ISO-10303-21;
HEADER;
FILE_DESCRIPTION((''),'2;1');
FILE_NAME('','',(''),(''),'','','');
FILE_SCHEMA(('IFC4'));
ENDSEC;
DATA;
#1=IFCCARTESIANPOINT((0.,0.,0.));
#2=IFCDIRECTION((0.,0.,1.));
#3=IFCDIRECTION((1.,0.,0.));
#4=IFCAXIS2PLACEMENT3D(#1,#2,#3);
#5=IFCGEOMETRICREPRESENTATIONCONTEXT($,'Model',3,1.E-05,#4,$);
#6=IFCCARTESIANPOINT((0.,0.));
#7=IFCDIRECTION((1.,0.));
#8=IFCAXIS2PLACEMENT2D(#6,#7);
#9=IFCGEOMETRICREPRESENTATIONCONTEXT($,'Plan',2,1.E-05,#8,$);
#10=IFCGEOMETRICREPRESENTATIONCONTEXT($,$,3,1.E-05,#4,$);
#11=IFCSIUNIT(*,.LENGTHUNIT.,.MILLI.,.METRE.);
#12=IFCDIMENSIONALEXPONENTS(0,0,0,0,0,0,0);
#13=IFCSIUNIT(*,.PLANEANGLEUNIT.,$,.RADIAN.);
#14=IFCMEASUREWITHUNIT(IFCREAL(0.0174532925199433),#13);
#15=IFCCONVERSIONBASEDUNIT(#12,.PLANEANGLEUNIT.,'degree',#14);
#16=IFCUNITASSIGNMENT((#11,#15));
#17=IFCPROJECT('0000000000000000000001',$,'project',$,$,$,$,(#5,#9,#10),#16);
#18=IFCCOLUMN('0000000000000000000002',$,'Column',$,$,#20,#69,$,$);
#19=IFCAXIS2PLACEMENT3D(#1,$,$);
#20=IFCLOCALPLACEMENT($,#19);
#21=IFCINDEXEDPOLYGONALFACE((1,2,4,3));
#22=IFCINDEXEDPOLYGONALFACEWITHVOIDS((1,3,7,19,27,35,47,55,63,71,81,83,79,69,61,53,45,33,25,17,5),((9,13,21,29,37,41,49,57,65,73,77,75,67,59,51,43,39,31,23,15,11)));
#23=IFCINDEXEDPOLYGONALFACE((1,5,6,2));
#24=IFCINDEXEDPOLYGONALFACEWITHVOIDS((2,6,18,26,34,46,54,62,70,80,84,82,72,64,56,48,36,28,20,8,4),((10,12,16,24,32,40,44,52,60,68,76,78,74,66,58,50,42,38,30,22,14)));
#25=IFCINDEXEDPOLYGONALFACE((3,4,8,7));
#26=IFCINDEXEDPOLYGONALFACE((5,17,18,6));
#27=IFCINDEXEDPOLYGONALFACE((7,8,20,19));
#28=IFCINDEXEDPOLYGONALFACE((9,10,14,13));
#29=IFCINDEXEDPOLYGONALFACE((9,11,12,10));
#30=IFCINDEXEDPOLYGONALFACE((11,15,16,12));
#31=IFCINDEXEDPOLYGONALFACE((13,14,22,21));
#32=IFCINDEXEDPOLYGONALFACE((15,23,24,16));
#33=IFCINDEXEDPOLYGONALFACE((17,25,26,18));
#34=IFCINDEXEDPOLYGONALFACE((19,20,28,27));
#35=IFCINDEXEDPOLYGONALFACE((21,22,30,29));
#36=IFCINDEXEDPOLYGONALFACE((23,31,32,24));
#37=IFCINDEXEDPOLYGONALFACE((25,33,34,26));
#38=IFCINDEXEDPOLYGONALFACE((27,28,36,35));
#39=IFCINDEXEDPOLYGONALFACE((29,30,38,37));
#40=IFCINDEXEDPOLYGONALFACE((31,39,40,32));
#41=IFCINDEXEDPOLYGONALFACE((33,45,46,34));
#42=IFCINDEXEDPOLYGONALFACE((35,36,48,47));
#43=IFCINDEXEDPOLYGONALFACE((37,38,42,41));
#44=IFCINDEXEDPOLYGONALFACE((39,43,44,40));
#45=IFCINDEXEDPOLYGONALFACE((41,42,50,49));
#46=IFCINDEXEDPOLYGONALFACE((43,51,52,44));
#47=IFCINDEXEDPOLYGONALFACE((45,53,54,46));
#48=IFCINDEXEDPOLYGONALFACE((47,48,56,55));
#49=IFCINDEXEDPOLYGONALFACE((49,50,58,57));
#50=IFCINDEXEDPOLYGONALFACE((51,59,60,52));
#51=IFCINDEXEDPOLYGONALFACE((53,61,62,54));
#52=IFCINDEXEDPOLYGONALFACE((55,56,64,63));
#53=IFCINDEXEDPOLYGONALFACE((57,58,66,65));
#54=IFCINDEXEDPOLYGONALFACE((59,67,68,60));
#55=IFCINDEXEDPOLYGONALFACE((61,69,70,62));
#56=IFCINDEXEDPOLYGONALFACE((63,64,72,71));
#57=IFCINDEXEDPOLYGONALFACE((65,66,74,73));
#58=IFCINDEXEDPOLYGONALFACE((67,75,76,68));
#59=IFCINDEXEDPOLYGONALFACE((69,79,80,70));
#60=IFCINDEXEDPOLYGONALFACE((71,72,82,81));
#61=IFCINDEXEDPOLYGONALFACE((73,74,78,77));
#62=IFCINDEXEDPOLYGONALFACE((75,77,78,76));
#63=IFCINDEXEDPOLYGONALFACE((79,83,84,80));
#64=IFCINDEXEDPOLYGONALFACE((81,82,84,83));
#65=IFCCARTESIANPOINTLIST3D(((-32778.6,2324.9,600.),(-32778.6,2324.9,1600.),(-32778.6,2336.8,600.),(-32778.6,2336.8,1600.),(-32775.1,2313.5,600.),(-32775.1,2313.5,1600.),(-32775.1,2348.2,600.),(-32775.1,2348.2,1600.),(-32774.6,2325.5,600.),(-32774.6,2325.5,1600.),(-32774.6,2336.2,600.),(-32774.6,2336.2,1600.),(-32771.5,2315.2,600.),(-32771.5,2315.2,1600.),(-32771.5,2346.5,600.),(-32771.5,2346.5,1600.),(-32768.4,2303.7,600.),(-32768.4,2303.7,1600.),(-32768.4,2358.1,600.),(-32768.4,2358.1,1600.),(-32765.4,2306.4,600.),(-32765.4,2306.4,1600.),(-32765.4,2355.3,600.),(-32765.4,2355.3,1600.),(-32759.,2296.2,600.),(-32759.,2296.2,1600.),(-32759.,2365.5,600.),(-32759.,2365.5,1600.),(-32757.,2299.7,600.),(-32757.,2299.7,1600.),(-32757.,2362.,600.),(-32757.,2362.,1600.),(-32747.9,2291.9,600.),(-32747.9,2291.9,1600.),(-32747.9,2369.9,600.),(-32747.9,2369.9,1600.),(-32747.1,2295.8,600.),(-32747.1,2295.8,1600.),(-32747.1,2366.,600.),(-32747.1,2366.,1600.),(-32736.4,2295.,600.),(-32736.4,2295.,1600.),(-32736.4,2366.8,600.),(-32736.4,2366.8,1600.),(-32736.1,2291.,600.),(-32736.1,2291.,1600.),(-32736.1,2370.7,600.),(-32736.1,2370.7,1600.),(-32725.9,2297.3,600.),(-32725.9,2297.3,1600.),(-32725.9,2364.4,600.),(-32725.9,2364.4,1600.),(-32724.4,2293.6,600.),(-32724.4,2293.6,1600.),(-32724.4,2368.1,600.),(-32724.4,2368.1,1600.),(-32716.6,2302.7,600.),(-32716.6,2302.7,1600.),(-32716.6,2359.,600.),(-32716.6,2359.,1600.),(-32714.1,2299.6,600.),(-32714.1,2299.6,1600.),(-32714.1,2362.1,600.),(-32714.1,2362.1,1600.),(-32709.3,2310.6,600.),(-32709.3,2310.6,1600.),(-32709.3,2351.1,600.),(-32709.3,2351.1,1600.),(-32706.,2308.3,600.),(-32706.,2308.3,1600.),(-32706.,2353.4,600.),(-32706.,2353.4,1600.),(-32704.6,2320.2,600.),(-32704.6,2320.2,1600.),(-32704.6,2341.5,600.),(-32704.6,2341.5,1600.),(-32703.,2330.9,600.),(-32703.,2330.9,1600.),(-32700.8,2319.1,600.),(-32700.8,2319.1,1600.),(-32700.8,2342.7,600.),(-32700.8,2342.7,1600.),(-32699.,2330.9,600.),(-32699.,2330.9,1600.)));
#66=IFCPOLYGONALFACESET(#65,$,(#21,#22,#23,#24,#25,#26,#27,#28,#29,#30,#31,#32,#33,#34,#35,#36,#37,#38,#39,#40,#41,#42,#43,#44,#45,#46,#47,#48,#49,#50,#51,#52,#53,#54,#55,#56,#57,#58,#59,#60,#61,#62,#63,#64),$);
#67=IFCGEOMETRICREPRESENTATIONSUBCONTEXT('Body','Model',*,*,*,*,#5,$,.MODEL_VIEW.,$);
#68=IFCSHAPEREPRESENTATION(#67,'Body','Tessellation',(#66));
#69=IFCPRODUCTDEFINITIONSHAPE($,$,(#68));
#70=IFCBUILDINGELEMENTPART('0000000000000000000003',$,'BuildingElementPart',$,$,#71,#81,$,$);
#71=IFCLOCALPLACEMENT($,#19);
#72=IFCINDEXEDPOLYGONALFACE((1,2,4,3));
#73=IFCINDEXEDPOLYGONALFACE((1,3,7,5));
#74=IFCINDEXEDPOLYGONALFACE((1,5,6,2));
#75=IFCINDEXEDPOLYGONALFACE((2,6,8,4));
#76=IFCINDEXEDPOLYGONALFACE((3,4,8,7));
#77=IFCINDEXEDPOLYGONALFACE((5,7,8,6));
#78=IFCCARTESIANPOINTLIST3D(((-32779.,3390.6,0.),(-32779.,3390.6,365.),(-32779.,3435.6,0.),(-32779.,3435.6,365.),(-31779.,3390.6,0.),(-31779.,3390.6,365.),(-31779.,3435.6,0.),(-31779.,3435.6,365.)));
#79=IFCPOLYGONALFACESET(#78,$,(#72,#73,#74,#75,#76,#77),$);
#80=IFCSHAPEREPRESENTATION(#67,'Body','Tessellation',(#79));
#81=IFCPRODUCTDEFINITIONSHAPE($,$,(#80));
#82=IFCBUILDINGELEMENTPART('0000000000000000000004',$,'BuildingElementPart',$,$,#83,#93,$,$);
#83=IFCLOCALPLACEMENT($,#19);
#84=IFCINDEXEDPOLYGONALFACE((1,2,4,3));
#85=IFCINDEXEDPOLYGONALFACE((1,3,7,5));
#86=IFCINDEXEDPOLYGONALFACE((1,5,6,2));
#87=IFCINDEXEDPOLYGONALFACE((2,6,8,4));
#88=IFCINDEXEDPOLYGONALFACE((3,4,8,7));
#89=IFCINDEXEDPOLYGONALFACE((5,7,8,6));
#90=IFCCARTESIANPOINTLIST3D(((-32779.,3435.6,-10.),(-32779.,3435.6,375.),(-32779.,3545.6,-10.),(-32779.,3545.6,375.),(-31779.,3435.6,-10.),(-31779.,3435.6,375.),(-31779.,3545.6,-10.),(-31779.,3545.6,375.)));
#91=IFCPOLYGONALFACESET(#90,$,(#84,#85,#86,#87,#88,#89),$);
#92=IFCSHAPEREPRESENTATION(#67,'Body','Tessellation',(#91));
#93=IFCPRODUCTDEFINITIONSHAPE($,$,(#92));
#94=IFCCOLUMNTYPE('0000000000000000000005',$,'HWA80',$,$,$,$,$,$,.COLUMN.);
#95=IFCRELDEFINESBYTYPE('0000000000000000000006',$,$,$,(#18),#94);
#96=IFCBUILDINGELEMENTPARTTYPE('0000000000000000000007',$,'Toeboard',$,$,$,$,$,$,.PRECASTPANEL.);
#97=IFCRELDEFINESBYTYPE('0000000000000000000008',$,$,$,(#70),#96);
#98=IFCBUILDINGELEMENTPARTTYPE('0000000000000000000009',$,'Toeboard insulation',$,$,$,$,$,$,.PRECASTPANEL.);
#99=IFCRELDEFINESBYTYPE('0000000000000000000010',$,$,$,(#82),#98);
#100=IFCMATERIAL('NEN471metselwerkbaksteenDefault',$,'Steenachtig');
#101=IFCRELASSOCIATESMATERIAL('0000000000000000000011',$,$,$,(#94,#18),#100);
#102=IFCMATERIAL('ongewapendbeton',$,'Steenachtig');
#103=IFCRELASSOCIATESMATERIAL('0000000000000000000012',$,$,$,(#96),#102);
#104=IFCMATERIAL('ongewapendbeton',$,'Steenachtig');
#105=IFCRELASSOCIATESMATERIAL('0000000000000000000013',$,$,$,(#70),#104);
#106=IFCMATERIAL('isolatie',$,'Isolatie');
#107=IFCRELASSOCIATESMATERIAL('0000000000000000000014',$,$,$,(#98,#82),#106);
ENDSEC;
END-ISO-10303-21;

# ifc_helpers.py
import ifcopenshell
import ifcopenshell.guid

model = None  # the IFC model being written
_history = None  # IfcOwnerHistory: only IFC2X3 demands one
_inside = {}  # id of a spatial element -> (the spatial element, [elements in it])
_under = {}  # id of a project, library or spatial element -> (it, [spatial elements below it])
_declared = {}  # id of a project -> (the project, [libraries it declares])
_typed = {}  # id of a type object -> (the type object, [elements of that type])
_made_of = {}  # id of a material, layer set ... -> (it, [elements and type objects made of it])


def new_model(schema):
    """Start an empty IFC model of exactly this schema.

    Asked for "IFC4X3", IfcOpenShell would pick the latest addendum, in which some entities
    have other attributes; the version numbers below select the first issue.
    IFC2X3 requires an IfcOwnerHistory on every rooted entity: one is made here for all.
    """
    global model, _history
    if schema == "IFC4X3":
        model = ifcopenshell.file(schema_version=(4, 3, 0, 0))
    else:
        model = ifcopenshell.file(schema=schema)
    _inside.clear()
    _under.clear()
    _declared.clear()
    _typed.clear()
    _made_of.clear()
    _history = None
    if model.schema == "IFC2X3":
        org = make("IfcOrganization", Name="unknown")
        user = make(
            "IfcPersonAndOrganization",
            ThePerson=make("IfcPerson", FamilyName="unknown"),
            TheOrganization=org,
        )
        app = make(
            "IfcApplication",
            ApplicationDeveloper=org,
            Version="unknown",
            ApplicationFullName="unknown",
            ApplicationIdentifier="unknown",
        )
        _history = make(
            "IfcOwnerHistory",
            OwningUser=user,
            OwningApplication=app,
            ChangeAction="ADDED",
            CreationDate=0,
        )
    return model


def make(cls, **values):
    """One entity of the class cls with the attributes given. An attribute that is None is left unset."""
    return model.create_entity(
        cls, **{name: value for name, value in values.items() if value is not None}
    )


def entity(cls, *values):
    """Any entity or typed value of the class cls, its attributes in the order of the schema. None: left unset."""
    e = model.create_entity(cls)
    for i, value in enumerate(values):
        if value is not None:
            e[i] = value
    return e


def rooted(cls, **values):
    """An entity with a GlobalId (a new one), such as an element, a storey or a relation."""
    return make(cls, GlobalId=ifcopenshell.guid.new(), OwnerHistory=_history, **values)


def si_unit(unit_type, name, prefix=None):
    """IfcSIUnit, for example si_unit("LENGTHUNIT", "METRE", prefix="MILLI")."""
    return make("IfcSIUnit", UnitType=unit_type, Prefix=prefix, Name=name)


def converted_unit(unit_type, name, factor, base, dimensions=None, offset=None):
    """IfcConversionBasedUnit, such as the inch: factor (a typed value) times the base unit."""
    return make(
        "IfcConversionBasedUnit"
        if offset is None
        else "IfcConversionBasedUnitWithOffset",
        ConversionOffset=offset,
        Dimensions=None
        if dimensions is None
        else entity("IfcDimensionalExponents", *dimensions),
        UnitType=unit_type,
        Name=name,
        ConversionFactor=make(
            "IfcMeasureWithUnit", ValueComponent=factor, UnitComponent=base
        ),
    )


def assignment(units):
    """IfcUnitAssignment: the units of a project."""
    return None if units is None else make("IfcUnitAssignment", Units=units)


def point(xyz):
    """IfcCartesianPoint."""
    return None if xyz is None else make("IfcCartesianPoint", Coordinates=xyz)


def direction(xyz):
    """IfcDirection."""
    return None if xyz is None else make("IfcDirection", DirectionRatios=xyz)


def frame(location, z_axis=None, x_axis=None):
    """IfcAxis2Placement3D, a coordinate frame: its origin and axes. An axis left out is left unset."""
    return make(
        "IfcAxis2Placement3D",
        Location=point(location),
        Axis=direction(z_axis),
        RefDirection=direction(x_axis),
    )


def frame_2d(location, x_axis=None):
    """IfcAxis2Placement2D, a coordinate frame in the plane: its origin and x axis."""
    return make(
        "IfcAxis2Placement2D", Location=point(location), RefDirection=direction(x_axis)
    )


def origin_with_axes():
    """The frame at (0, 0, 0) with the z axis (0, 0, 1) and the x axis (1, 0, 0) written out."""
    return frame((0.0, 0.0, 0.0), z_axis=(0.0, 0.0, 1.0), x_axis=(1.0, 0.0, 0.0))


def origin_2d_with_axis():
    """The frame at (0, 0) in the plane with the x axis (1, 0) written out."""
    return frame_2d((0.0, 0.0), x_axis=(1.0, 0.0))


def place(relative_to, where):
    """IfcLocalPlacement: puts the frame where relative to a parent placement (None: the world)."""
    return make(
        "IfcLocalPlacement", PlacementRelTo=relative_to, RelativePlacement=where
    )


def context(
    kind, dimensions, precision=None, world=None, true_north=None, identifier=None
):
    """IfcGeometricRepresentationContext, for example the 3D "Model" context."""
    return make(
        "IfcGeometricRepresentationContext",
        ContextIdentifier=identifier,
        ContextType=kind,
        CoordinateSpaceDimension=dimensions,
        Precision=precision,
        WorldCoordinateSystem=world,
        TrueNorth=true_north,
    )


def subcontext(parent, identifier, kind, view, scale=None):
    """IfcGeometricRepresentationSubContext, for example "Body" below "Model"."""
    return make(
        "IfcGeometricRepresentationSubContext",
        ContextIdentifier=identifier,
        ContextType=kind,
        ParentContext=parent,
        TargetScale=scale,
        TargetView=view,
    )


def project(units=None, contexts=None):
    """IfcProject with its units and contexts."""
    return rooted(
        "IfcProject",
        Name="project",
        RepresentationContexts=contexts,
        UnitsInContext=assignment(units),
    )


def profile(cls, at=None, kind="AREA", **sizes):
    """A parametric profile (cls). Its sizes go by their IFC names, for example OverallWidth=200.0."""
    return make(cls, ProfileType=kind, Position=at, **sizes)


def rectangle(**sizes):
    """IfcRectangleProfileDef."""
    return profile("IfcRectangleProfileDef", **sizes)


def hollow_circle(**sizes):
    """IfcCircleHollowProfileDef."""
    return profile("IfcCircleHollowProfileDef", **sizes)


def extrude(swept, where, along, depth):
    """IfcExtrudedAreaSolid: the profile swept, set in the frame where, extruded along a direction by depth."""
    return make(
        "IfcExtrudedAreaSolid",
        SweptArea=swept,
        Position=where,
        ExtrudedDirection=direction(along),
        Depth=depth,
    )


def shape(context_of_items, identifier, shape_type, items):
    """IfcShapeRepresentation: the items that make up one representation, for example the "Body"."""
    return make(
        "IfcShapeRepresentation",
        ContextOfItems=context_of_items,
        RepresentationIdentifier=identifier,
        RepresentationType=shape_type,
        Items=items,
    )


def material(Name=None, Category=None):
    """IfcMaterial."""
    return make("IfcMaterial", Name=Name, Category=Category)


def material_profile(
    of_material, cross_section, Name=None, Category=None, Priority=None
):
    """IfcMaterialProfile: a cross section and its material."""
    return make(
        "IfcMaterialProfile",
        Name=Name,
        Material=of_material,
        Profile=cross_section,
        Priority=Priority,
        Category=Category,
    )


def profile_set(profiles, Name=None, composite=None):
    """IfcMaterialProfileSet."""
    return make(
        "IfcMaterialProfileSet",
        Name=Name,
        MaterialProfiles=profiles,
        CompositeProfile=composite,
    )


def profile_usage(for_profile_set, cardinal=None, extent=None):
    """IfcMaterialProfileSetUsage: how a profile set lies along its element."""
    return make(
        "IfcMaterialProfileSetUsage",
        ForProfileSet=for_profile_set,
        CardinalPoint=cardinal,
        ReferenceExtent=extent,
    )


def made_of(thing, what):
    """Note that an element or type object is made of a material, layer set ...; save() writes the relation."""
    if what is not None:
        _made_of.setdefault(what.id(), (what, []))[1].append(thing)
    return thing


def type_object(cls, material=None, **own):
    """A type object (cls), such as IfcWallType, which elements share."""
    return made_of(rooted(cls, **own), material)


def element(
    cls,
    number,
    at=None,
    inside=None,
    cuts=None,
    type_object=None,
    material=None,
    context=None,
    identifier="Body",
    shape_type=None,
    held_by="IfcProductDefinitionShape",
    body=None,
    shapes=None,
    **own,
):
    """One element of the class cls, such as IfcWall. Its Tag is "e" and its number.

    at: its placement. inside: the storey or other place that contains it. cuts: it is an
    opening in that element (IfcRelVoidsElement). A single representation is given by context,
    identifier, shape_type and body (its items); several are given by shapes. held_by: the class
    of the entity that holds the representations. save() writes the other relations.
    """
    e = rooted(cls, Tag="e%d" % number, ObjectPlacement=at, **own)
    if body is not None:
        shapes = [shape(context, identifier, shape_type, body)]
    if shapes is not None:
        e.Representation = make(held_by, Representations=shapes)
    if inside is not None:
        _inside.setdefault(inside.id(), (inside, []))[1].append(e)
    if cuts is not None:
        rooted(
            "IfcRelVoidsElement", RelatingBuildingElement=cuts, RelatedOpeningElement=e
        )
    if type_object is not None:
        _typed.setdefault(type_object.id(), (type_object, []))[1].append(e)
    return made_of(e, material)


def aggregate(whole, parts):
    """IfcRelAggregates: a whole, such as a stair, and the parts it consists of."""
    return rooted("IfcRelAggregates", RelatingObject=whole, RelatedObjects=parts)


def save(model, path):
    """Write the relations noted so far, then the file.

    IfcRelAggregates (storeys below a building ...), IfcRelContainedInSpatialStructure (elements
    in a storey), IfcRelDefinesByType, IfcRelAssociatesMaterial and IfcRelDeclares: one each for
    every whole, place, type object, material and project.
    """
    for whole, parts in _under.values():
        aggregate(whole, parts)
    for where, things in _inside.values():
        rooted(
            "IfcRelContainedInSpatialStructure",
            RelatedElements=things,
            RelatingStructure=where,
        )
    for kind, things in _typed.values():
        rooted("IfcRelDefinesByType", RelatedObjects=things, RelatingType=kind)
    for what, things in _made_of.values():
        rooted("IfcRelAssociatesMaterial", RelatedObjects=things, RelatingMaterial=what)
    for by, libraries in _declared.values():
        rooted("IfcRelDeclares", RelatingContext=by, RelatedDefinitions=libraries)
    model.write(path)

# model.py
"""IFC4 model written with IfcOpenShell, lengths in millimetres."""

from ifc_helpers import new_model, entity, si_unit, converted_unit, frame, origin_with_axes, origin_2d_with_axis, place, context, subcontext, project, rectangle, hollow_circle, extrude, material, material_profile, profile_set, profile_usage, type_object, element, save


model = new_model("IFC4")

# Units and contexts
model_context = context("Model", 3, precision=1e-05, world=origin_with_axes())
plan_context = context("Plan", 2, precision=1e-05, world=origin_2d_with_axis())
context_of_model = context(None, 3, precision=1e-05, world=origin_with_axes())
body_context = subcontext(model_context, "Body", "Model", "MODEL_VIEW")
ifc_project = project(units=[si_unit("LENGTHUNIT", "METRE", prefix="MILLI"), converted_unit("PLANEANGLEUNIT", "degree", entity("IfcReal", 0.0174532925199433), si_unit("PLANEANGLEUNIT", "RADIAN"), dimensions=[0, 0, 0, 0, 0, 0, 0])], contexts=[model_context, plan_context, context_of_model])

# Column
ifc_material_1 = material(Name="NEN471metselwerkbaksteenDefault", Category="Steenachtig")
ifc_material_profile_1 = material_profile(ifc_material_1, hollow_circle(Radius=40.0, WallThickness=4.0))
ifc_profile_set_1 = profile_set([ifc_material_profile_1])
ifc_profile_usage_1 = profile_usage(ifc_profile_set_1, cardinal=5)
column_type = type_object("IfcColumnType", Name="HWA80", PredefinedType="COLUMN", material=ifc_profile_set_1)
column_placement = place(None, frame((-32739.0, 2330.9, 600.0), z_axis=(0.0, 0.0, 1.0), x_axis=(1.0, 0.0, 0.0)))
element("IfcColumn", 1, at=column_placement, type_object=column_type, material=ifc_profile_usage_1, Name="Column", context=body_context, shape_type="SweptSolid", body=[
    extrude(hollow_circle(Radius=40.0, WallThickness=4.0), origin_with_axes(), (0.0, 0.0, 1.0), 1000.0),
])

# Building element parts
ifc_material_2 = material(Name="ongewapendbeton", Category="Steenachtig")
ifc_material_3 = material(Name="ongewapendbeton", Category="Steenachtig")
ifc_material_profile_2 = material_profile(ifc_material_3, rectangle(XDim=45.0, YDim=365.0))
ifc_profile_set_2 = profile_set([ifc_material_profile_2], Name="ongewapendbeton")
building_element_part_type_1 = type_object("IfcBuildingElementPartType", Name="Toeboard", PredefinedType="PRECASTPANEL", material=ifc_profile_set_2)
building_element_part_1_placement = place(None, frame((-32779.0, 3413.1, 182.5), z_axis=(1.0, 0.0, 0.0), x_axis=(0.0, 1.0, 0.0)))
element("IfcBuildingElementPart", 2, at=building_element_part_1_placement, type_object=building_element_part_type_1, material=ifc_material_2, Name="BuildingElementPart", context=body_context, shape_type="SweptSolid", body=[
    extrude(rectangle(XDim=45.0, YDim=365.0), origin_with_axes(), (0.0, 0.0, 1.0), 1000.0),
])
ifc_material_4 = material(Name="isolatie", Category="Isolatie")
ifc_material_profile_3 = material_profile(ifc_material_4, rectangle(XDim=110.0, YDim=385.0))
ifc_profile_set_3 = profile_set([ifc_material_profile_3], Name="isolatieEPS")
ifc_profile_usage_2 = profile_usage(ifc_profile_set_3, cardinal=5)
building_element_part_type_2 = type_object("IfcBuildingElementPartType", Name="Toeboard insulation", PredefinedType="PRECASTPANEL", material=ifc_profile_set_3)
building_element_part_2_placement = place(None, frame((-32779.0, 3490.6, 182.5), z_axis=(1.0, 0.0, 0.0), x_axis=(0.0, 1.0, 0.0)))
element("IfcBuildingElementPart", 3, at=building_element_part_2_placement, type_object=building_element_part_type_2, material=ifc_profile_usage_2, Name="BuildingElementPart", context=body_context, shape_type="SweptSolid", body=[
    extrude(rectangle(XDim=110.0, YDim=385.0), origin_with_axes(), (0.0, 0.0, 1.0), 1000.0),
])

save(model, "model.ifc")
